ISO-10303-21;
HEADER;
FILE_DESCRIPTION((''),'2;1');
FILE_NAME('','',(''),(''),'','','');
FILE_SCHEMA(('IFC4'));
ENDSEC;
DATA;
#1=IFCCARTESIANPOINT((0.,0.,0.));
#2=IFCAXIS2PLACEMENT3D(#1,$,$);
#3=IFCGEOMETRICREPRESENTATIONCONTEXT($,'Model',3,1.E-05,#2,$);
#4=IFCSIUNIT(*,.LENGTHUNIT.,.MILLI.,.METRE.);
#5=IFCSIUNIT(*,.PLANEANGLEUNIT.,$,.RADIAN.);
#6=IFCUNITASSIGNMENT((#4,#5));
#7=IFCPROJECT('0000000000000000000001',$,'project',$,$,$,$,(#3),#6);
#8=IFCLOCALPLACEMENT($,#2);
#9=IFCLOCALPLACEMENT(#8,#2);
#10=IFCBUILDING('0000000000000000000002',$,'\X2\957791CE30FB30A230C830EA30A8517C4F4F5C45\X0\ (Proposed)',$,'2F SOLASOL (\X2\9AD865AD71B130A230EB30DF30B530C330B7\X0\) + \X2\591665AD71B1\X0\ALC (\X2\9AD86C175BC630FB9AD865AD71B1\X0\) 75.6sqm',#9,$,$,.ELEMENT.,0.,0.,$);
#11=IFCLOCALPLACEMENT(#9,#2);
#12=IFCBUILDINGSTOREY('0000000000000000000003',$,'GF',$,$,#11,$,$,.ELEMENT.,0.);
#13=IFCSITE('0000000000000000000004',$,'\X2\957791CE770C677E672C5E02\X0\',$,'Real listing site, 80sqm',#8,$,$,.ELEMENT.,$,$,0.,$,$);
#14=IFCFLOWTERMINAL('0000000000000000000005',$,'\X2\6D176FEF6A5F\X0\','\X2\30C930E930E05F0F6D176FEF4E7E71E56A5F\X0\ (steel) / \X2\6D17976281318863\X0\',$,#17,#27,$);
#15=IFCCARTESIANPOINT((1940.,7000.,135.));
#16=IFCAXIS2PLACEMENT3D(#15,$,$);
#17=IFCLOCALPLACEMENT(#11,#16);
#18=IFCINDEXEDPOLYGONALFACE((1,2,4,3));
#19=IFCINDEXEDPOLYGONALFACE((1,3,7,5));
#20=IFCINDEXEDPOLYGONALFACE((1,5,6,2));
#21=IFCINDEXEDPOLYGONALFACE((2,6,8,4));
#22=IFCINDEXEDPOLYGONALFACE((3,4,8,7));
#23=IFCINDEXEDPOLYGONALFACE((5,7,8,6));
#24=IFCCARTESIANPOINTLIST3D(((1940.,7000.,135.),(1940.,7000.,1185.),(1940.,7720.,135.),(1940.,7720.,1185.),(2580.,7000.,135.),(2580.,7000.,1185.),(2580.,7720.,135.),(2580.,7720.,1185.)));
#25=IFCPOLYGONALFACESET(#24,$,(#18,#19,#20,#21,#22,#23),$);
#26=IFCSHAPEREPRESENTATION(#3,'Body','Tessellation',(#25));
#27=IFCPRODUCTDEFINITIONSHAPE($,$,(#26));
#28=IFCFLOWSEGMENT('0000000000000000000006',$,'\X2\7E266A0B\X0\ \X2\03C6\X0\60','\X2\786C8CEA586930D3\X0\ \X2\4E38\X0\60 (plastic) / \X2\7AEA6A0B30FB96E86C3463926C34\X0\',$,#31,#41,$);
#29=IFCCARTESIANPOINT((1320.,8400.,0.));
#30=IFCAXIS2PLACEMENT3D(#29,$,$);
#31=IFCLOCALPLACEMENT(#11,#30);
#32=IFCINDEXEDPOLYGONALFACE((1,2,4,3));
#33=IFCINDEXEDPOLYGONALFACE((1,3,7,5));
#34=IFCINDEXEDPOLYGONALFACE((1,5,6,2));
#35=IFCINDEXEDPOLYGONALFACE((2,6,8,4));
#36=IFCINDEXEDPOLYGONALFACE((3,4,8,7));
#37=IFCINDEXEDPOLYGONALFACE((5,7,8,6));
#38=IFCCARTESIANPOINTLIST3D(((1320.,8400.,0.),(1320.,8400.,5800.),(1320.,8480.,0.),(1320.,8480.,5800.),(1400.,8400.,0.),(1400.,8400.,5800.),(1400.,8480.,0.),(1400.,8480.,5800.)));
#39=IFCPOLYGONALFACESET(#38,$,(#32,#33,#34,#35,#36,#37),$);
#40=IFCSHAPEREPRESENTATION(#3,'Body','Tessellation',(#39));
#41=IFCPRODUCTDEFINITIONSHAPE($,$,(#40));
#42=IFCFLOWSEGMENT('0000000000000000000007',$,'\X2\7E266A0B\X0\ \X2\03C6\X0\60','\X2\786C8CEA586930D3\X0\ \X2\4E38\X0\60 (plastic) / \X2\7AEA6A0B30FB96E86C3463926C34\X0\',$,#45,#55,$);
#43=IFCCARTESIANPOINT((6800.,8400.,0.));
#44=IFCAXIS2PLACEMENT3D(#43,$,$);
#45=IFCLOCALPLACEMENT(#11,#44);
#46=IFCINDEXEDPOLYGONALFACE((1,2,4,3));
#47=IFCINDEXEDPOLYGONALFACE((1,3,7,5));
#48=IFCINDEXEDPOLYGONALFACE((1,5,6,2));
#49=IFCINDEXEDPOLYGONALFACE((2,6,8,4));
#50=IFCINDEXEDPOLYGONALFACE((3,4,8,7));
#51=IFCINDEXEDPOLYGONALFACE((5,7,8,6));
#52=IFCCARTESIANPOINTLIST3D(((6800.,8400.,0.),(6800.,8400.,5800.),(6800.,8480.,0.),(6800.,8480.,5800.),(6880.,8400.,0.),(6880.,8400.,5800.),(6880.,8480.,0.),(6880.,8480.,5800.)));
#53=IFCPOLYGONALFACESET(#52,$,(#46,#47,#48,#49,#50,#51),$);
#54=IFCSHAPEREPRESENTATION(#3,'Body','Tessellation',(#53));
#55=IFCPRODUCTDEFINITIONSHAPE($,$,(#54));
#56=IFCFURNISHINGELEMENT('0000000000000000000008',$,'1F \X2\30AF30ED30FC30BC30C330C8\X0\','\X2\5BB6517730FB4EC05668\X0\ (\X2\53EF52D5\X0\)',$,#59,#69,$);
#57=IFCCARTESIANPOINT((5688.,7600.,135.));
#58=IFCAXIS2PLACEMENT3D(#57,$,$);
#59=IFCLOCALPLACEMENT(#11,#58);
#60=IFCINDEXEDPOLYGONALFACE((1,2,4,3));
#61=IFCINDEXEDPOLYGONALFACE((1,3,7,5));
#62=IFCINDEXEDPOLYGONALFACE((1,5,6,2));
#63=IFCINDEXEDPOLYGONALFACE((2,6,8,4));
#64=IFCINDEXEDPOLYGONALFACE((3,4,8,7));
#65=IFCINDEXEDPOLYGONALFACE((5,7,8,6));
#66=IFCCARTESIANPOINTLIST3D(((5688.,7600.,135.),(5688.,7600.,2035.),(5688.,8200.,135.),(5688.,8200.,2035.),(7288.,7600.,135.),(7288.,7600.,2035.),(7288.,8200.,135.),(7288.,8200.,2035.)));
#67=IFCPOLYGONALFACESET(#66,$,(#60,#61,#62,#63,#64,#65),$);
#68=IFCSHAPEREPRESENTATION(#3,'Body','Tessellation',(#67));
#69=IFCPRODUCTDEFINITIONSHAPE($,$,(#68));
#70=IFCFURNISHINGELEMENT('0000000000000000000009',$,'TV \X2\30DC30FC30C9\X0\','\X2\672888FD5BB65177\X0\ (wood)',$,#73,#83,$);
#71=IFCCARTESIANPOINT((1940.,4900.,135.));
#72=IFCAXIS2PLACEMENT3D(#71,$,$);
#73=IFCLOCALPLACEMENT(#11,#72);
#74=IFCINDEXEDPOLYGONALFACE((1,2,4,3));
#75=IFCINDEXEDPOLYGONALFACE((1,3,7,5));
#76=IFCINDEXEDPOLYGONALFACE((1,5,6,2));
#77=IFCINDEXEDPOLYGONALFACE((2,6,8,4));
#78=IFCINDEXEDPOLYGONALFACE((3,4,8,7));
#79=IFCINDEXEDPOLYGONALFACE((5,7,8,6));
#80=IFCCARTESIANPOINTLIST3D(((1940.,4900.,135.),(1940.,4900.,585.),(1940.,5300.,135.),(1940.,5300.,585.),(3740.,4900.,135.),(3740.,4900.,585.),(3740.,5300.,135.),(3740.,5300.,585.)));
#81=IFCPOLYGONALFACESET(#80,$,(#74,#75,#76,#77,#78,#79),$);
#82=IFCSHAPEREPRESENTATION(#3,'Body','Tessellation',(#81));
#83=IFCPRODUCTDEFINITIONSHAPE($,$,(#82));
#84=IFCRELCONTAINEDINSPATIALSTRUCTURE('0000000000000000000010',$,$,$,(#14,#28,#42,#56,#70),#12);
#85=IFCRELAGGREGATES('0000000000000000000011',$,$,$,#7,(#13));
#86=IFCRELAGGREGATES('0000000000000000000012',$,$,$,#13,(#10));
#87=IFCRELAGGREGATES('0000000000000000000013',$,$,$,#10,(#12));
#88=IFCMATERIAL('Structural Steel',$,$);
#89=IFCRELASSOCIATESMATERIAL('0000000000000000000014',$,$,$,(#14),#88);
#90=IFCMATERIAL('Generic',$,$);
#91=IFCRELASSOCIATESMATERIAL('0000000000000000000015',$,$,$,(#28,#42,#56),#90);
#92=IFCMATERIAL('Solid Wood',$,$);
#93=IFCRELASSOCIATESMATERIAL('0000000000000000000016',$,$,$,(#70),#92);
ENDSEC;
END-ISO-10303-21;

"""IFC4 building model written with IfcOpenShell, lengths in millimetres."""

from ifc_helpers import new_model, si_unit, frame, frame_2d, origin, place, context, project, spatial, rectangle, extrude, material, element, save


model = new_model("IFC4")

# Units and contexts
model_context = context("Model", 3, precision=1e-05, world=origin())
ifc_project = project(units=[si_unit("LENGTHUNIT", "METRE", prefix="MILLI"), si_unit("PLANEANGLEUNIT", "RADIAN")], contexts=[model_context])

# Site, building, storey
site_placement = place(None, origin())
site = spatial("IfcSite", under=ifc_project, at=site_placement, Name="長野県松本市", ObjectType="Real listing site, 80sqm", CompositionType="ELEMENT", RefElevation=0.0)
building_placement = place(site_placement, origin())
building = spatial("IfcBuilding", under=site, at=building_placement, Name="長野・アトリエ兼住居 (Proposed)", ObjectType="2F SOLASOL (高断熱アルミサッシ) + 外断熱ALC (高気密・高断熱) 75.6sqm", CompositionType="ELEMENT", ElevationOfRefHeight=0.0, ElevationOfTerrain=0.0)
storey_placement = place(building_placement, origin())
storey = spatial("IfcBuildingStorey", under=building, at=storey_placement, Name="GF", CompositionType="ELEMENT", Elevation=0.0)

# Shared definitions
ifc_material_1 = material(Name="Solid Wood")

# Shared definitions
ifc_material_2 = material(Name="Generic")

# Shared definitions
ifc_material_3 = material(Name="Structural Steel")

# Flow terminal
flow_terminal_placement = place(storey_placement, frame((1940.0, 7000.0, 135.0)))
element("IfcFlowTerminal", 1, at=flow_terminal_placement, inside=storey, material=ifc_material_3, Name="洗濯機", Description="ドラム式洗濯乾燥機 (steel) / 洗面脱衣", context=model_context, shape_type="SweptSolid", body=[
    extrude(rectangle(XDim=640.0, YDim=720.0, at=frame_2d((320.0, 360.0))), frame((1940.0, 7000.0, 135.0)), (0.0, 0.0, 1.0), 1050.0),
])

# Flow segments
flow_segment_1_placement = place(storey_placement, frame((1320.0, 8400.0, 0.0)))
element("IfcFlowSegment", 2, at=flow_segment_1_placement, inside=storey, material=ifc_material_2, Name="縦樋 φ60", Description="硬質塩ビ 丸60 (plastic) / 竪樋・雨水排水", context=model_context, shape_type="SweptSolid", body=[
    extrude(rectangle(XDim=80.0, YDim=80.0, at=frame_2d((40.0, 40.0))), frame((1320.0, 8400.0, 0.0)), (0.0, 0.0, 1.0), 5800.0),
])
flow_segment_2_placement = place(storey_placement, frame((6800.0, 8400.0, 0.0)))
element("IfcFlowSegment", 3, at=flow_segment_2_placement, inside=storey, material=ifc_material_2, Name="縦樋 φ60", Description="硬質塩ビ 丸60 (plastic) / 竪樋・雨水排水", context=model_context, shape_type="SweptSolid", body=[
    extrude(rectangle(XDim=80.0, YDim=80.0, at=frame_2d((40.0, 40.0))), frame((6800.0, 8400.0, 0.0)), (0.0, 0.0, 1.0), 5800.0),
])

# Furnishing elements
furnishing_1_placement = place(storey_placement, frame((5688.0, 7600.0, 135.0)))
element("IfcFurnishingElement", 4, at=furnishing_1_placement, inside=storey, material=ifc_material_2, Name="1F クローゼット", Description="家具・什器 (可動)", context=model_context, shape_type="SweptSolid", body=[
    extrude(rectangle(XDim=1600.0, YDim=600.0, at=frame_2d((800.0, 300.0))), frame((5688.0, 7600.0, 135.0)), (0.0, 0.0, 1.0), 1900.0),
])
furnishing_2_placement = place(storey_placement, frame((1940.0, 4900.0, 135.0)))
element("IfcFurnishingElement", 5, at=furnishing_2_placement, inside=storey, material=ifc_material_1, Name="TV ボード", Description="木製家具 (wood)", context=model_context, shape_type="SweptSolid", body=[
    extrude(rectangle(XDim=1800.0, YDim=400.0, at=frame_2d((900.0, 200.0))), frame((1940.0, 4900.0, 135.0)), (0.0, 0.0, 1.0), 450.0),
])

save(model, "model.ifc")
